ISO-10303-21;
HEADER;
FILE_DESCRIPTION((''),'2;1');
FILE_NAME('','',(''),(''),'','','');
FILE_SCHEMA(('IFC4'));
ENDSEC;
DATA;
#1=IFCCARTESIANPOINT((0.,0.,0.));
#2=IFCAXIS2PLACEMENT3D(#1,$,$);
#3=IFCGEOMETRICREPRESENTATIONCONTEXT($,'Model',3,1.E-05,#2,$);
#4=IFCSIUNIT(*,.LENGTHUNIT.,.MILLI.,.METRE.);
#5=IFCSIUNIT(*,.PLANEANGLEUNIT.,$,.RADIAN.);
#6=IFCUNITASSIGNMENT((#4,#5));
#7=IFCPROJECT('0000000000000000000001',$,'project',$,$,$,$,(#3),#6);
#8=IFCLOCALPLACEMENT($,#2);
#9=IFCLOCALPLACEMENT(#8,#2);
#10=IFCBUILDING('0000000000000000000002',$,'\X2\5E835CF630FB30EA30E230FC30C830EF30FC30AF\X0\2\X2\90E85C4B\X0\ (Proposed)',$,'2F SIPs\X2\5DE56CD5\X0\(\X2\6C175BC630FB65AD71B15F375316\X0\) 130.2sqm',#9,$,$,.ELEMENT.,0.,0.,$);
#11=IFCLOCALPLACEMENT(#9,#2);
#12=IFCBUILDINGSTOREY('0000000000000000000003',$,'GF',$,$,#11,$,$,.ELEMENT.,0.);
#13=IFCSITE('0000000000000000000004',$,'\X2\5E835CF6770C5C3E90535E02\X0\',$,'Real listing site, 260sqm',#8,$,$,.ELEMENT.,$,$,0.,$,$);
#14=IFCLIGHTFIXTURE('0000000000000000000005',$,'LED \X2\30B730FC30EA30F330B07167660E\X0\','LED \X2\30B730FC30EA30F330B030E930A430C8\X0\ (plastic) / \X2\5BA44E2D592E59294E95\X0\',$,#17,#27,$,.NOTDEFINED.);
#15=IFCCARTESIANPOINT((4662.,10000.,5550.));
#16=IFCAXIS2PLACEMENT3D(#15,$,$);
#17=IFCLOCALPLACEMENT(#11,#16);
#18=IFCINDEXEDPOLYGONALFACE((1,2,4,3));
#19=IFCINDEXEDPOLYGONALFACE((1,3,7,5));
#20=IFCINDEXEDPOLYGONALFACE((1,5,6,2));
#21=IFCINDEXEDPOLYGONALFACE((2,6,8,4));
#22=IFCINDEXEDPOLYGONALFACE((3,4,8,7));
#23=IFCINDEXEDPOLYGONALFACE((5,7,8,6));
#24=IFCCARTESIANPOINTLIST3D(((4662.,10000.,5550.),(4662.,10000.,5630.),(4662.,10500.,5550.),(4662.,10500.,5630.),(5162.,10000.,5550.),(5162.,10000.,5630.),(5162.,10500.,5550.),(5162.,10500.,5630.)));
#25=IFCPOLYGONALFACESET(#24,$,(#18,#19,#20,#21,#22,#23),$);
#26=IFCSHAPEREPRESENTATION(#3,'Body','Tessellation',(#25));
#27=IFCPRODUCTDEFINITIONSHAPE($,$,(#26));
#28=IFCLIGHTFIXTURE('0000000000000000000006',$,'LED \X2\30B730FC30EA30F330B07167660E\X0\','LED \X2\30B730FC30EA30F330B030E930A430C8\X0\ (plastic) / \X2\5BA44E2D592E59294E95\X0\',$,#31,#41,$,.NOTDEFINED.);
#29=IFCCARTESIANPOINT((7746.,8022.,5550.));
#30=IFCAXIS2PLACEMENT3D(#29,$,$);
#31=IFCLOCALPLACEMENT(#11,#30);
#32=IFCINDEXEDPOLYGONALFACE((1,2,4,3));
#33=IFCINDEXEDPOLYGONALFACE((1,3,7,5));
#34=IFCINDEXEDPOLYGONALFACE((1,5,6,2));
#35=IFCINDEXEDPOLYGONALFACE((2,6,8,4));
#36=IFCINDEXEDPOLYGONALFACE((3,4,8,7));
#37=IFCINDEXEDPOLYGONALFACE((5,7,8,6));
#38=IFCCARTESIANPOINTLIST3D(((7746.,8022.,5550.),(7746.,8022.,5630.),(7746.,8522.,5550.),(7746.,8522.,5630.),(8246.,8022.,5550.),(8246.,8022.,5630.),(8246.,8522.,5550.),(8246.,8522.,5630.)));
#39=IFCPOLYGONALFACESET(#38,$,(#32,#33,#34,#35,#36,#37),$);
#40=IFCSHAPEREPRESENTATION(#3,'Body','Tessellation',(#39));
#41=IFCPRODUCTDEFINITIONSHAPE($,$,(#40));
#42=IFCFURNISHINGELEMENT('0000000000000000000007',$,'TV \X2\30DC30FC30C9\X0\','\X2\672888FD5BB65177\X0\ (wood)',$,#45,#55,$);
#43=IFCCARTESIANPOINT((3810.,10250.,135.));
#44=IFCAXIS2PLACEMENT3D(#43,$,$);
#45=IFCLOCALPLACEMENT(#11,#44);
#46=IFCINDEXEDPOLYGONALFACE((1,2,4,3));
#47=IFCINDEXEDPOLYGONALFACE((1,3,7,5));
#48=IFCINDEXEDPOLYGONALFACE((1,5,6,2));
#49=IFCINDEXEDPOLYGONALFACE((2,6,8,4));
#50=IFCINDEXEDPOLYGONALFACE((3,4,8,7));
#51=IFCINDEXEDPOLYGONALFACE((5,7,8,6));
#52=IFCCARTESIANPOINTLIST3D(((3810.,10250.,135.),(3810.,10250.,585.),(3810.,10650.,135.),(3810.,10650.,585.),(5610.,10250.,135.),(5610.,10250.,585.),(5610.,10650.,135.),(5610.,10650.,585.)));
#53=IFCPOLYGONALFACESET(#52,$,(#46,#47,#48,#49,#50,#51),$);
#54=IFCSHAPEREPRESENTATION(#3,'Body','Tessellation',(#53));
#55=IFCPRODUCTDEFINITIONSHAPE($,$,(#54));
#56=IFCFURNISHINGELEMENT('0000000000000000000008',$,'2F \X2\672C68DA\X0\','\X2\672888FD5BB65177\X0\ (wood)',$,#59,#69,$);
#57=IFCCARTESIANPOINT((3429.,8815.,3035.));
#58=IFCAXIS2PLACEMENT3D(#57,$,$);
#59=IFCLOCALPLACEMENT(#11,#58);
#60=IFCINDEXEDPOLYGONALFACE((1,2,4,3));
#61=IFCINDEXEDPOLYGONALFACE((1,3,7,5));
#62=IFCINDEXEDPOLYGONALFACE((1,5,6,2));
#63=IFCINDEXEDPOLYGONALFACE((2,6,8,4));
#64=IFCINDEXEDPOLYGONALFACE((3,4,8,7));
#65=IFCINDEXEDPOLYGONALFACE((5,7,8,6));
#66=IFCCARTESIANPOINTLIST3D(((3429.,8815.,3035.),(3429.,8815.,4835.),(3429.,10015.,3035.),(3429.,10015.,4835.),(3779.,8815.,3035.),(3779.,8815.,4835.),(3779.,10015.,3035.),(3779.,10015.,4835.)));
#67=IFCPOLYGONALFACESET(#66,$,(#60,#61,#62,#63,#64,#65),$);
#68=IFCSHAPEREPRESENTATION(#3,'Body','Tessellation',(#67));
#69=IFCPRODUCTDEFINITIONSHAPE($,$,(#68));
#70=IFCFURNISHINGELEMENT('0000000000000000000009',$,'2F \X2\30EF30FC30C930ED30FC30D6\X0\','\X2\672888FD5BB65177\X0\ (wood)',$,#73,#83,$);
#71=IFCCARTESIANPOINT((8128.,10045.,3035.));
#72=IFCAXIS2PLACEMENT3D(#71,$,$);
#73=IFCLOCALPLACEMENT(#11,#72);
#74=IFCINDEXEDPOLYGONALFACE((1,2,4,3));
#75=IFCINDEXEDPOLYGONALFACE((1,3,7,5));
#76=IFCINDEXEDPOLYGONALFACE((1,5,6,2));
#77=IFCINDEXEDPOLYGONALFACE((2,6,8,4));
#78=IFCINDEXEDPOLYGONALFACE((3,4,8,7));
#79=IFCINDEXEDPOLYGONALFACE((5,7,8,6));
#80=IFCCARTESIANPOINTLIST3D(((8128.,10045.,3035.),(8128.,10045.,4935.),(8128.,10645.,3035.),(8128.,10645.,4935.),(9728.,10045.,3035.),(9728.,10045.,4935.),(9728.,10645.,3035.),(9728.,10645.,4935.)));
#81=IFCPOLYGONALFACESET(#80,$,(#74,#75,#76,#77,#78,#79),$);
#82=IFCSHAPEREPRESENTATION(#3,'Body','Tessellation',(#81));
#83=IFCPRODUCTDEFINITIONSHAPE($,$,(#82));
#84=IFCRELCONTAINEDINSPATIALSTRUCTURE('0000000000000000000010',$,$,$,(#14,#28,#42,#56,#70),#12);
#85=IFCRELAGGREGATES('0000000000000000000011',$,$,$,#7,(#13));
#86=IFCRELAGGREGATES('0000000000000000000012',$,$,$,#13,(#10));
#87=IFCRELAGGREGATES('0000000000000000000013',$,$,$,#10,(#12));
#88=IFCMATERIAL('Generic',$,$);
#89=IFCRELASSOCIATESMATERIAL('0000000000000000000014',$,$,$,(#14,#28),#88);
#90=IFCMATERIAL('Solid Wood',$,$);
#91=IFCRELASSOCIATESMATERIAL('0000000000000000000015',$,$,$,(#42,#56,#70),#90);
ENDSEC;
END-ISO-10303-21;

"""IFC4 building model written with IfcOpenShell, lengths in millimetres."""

from ifc_helpers import new_model, si_unit, frame, frame_2d, origin, place, context, project, spatial, rectangle, extrude, material, element, save


model = new_model("IFC4")

# Units and contexts
model_context = context("Model", 3, precision=1e-05, world=origin())
ifc_project = project(units=[si_unit("LENGTHUNIT", "METRE", prefix="MILLI"), si_unit("PLANEANGLEUNIT", "RADIAN")], contexts=[model_context])

# Site, building, storey
site_placement = place(None, origin())
site = spatial("IfcSite", under=ifc_project, at=site_placement, Name="広島県尾道市", ObjectType="Real listing site, 260sqm", CompositionType="ELEMENT", RefElevation=0.0)
building_placement = place(site_placement, origin())
building = spatial("IfcBuilding", under=site, at=building_placement, Name="広島・リモートワーク2部屋 (Proposed)", ObjectType="2F SIPs工法(気密・断熱強化) 130.2sqm", CompositionType="ELEMENT", ElevationOfRefHeight=0.0, ElevationOfTerrain=0.0)
storey_placement = place(building_placement, origin())
storey = spatial("IfcBuildingStorey", under=building, at=storey_placement, Name="GF", CompositionType="ELEMENT", Elevation=0.0)

# Shared definitions
ifc_material_1 = material(Name="Solid Wood")

# Shared definitions
ifc_material_2 = material(Name="Generic")

# Light fixtures
light_fixture_1_placement = place(storey_placement, frame((4662.0, 10000.0, 5550.0)))
element("IfcLightFixture", 1, at=light_fixture_1_placement, inside=storey, material=ifc_material_2, Name="LED シーリング照明", Description="LED シーリングライト (plastic) / 室中央天井", PredefinedType="NOTDEFINED", context=model_context, shape_type="SweptSolid", body=[
    extrude(rectangle(XDim=500.0, YDim=500.0, at=frame_2d((250.0, 250.0))), frame((4662.0, 10000.0, 5550.0)), (0.0, 0.0, 1.0), 80.0),
])
light_fixture_2_placement = place(storey_placement, frame((7746.0, 8022.0, 5550.0)))
element("IfcLightFixture", 2, at=light_fixture_2_placement, inside=storey, material=ifc_material_2, Name="LED シーリング照明", Description="LED シーリングライト (plastic) / 室中央天井", PredefinedType="NOTDEFINED", context=model_context, shape_type="SweptSolid", body=[
    extrude(rectangle(XDim=500.0, YDim=500.0, at=frame_2d((250.0, 250.0))), frame((7746.0, 8022.0, 5550.0)), (0.0, 0.0, 1.0), 80.0),
])

# Furnishing elements
furnishing_1_placement = place(storey_placement, frame((3810.0, 10250.0, 135.0)))
element("IfcFurnishingElement", 3, at=furnishing_1_placement, inside=storey, material=ifc_material_1, Name="TV ボード", Description="木製家具 (wood)", context=model_context, shape_type="SweptSolid", body=[
    extrude(rectangle(XDim=1800.0, YDim=400.0, at=frame_2d((900.0, 200.0))), frame((3810.0, 10250.0, 135.0)), (0.0, 0.0, 1.0), 450.0),
])
furnishing_2_placement = place(storey_placement, frame((3429.0, 8815.0, 3035.0)))
element("IfcFurnishingElement", 4, at=furnishing_2_placement, inside=storey, material=ifc_material_1, Name="2F 本棚", Description="木製家具 (wood)", context=model_context, shape_type="SweptSolid", body=[
    extrude(rectangle(XDim=350.0, YDim=1200.0, at=frame_2d((175.0, 600.0))), frame((3429.0, 8815.0, 3035.0)), (0.0, 0.0, 1.0), 1800.0),
])
furnishing_3_placement = place(storey_placement, frame((8128.0, 10045.0, 3035.0)))
element("IfcFurnishingElement", 5, at=furnishing_3_placement, inside=storey, material=ifc_material_1, Name="2F ワードローブ", Description="木製家具 (wood)", context=model_context, shape_type="SweptSolid", body=[
    extrude(rectangle(XDim=1600.0, YDim=600.0, at=frame_2d((800.0, 300.0))), frame((8128.0, 10045.0, 3035.0)), (0.0, 0.0, 1.0), 1900.0),
])

save(model, "model.ifc")
